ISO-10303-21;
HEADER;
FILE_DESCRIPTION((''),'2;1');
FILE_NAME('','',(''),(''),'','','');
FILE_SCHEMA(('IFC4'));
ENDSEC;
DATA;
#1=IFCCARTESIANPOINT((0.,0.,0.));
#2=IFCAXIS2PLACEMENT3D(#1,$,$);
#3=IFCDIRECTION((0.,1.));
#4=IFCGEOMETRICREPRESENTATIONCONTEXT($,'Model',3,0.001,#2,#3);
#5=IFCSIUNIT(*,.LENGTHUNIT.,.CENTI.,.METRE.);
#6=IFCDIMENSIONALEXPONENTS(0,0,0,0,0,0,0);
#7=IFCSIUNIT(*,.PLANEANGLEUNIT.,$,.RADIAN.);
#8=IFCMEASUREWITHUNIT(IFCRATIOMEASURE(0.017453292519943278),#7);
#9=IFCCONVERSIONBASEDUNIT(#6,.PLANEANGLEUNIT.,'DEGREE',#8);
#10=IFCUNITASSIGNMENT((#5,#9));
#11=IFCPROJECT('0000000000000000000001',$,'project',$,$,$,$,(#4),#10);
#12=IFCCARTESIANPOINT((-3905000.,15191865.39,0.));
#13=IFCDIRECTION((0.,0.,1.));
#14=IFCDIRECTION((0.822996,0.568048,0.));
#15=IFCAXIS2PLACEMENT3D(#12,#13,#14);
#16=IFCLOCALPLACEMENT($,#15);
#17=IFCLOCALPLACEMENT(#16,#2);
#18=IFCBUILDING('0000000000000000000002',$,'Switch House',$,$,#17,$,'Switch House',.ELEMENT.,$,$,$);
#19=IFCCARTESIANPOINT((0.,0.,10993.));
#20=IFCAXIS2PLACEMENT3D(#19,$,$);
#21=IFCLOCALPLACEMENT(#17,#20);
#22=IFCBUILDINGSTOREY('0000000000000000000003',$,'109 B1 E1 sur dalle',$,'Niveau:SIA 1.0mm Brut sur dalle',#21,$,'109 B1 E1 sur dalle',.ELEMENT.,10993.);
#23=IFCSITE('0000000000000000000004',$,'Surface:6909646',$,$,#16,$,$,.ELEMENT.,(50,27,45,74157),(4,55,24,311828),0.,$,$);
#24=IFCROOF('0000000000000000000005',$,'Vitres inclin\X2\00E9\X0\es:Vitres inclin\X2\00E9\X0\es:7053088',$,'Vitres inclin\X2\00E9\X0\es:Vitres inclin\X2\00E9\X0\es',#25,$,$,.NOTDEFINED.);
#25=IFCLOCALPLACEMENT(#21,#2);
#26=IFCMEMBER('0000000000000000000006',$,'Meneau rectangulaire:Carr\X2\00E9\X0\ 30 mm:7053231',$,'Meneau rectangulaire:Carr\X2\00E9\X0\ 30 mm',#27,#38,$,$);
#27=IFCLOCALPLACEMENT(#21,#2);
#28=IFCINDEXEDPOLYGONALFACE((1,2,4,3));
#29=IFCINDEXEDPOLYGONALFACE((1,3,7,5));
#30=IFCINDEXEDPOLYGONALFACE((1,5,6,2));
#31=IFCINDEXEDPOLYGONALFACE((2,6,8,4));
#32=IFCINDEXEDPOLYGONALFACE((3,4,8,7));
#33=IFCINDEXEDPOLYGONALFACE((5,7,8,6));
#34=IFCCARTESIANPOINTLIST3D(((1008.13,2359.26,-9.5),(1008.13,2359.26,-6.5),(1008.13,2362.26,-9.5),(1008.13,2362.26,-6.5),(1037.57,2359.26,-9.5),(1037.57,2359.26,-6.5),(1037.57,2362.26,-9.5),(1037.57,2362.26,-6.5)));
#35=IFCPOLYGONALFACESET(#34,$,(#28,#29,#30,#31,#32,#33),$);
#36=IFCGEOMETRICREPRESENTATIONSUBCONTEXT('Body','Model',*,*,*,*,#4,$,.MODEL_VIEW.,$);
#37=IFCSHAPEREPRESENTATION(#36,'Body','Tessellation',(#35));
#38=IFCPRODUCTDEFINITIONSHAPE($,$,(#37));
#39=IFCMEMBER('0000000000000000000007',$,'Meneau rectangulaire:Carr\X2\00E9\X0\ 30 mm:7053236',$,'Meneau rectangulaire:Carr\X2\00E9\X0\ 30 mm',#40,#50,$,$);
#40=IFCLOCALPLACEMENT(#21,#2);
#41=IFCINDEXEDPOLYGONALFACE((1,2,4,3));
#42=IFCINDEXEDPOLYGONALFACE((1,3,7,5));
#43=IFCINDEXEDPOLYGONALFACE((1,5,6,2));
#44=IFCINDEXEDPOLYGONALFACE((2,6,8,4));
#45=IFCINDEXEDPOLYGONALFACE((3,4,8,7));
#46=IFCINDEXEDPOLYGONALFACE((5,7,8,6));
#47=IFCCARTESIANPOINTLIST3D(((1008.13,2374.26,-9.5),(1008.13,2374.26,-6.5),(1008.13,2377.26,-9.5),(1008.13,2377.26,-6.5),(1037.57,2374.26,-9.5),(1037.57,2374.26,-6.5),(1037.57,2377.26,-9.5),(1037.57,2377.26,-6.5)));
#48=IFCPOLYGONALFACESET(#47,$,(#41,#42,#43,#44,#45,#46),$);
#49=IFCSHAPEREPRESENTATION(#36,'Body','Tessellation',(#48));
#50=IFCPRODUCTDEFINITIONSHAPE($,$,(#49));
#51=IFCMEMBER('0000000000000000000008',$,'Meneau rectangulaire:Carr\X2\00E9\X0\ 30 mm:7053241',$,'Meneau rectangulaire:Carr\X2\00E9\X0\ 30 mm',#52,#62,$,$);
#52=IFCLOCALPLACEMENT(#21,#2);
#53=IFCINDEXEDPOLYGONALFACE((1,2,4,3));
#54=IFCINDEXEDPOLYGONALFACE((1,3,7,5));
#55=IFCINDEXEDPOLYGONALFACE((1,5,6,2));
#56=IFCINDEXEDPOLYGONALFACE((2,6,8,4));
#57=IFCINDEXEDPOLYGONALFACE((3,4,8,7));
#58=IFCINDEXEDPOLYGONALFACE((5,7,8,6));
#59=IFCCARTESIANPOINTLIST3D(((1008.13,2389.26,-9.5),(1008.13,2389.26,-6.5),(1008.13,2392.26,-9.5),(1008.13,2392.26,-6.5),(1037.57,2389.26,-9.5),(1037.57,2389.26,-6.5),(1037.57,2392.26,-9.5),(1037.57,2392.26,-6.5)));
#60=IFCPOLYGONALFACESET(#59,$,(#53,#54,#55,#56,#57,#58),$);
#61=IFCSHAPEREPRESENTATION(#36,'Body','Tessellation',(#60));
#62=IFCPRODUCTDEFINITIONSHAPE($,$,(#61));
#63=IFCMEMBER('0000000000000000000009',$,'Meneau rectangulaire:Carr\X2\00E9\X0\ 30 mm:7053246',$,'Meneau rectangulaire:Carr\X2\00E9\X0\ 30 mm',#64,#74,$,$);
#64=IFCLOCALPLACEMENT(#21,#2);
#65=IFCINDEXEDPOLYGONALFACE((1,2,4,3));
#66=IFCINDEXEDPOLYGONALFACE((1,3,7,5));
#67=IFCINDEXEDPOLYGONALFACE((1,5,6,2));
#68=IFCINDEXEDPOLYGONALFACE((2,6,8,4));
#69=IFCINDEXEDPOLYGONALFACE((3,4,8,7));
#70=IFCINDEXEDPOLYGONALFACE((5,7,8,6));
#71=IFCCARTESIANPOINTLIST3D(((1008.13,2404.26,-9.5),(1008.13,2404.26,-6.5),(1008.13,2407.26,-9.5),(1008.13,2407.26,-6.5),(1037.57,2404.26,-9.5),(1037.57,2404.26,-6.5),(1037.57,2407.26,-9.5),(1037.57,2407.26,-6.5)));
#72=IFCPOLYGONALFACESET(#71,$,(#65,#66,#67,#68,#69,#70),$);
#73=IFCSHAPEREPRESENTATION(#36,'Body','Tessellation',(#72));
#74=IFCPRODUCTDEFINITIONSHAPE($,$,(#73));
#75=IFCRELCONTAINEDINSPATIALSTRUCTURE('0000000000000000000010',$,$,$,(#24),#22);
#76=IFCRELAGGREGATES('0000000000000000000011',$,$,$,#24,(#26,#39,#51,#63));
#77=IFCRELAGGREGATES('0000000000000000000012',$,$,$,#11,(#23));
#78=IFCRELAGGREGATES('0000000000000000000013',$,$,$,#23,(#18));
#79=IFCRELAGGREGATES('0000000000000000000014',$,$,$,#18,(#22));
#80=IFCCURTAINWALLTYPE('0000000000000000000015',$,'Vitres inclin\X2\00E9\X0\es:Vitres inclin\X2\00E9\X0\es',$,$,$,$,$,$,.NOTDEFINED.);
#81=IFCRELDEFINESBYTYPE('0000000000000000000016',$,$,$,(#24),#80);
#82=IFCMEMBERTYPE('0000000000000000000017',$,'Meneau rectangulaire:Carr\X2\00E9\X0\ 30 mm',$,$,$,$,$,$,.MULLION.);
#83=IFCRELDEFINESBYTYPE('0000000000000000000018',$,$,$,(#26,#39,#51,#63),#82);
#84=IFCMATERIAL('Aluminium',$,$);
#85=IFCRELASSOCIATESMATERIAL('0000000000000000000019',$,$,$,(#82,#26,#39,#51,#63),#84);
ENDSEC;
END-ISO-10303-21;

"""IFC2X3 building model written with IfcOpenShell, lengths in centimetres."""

from ifc_helpers import new_model, entity, si_unit, converted_unit, direction, frame, origin, origin_2d_with_axis, place, context, subcontext, project, spatial, rectangle, extrude, source, transform, mapped, material, type_object, type_shapes, element, aggregate, save


model = new_model("IFC2X3")

# Units and contexts
model_context = context("Model", 3, precision=0.001, world=origin(), true_north=direction((0.0, 1.0)))
body_context = subcontext(model_context, "Body", "Model", "MODEL_VIEW")
ifc_project = project(units=[si_unit("LENGTHUNIT", "METRE", prefix="CENTI"), converted_unit("PLANEANGLEUNIT", "DEGREE", entity("IfcRatioMeasure", 0.017453292519943278), si_unit("PLANEANGLEUNIT", "RADIAN"), dimensions=[0, 0, 0, 0, 0, 0, 0])], contexts=[model_context])

# Site, building, storey
site_placement = place(None, frame((-3905000.0, 15191865.39, 0.0), z_axis=(0.0, 0.0, 1.0), x_axis=(0.822996, 0.568048, 0.0)))
site = spatial("IfcSite", under=ifc_project, at=site_placement, Name="Surface:6909646", CompositionType="ELEMENT", RefLatitude=(50, 27, 45, 74157), RefLongitude=(4, 55, 24, 311828), RefElevation=0.0)
building_placement = place(site_placement, origin())
building = spatial("IfcBuilding", under=site, at=building_placement, Name="Switch House", LongName="Switch House", CompositionType="ELEMENT")
storey_placement = place(building_placement, frame((0.0, 0.0, 10993.0)))
storey = spatial("IfcBuildingStorey", under=building, at=storey_placement, Name="109 B1 E1 sur dalle", ObjectType="Niveau:SIA 1.0mm Brut sur dalle", LongName="109 B1 E1 sur dalle", CompositionType="ELEMENT", Elevation=10993.0)

# Roof, members
curtain_wall_type = type_object("IfcCurtainWallType", Name="Vitres inclinées:Vitres inclinées", PredefinedType="NOTDEFINED")
roof_placement = place(storey_placement, frame((0.0, 0.0, -10993.0)))
roof = element("IfcRoof", 1, at=roof_placement, inside=storey, type_object=curtain_wall_type, Name="Vitres inclinées:Vitres inclinées:7053088", ObjectType="Vitres inclinées:Vitres inclinées", ShapeType="NOTDEFINED")
ifc_material = material(Name="Aluminium")
member_type_1 = type_object("IfcMemberType", Name="Meneau rectangulaire:Carré 30 mm", PredefinedType="MULLION", material=ifc_material)
shared_shape_1 = source(origin(), body_context, "Body", "SweptSolid", [
    extrude(rectangle(XDim=3.0, YDim=3.0, at=origin_2d_with_axis()), frame((0.0, 0.0, -29.44), z_axis=(0.0, 0.0, 1.0), x_axis=(0.0, -1.0, 0.0)), (0.0, 0.0, 1.0), 29.44),
])
type_shapes(member_type_1, [shared_shape_1])
member_1_placement = place(roof_placement, frame((1008.13, 2360.76, 10985.0), z_axis=(-1.0, 0.0, 0.0), x_axis=(0.0, 1.0, 0.0)))
member_1 = element("IfcMember", 2, at=member_1_placement, type_object=member_type_1, material=ifc_material, Name="Meneau rectangulaire:Carré 30 mm:7053231", ObjectType="Meneau rectangulaire:Carré 30 mm", context=body_context, shape_type="MappedRepresentation", body=[
    mapped(shared_shape_1, transform((0.0, 0.0, 0.0), scale=1.0)),
])
member_2_placement = place(roof_placement, frame((1008.13, 2375.76, 10985.0), z_axis=(-1.0, 0.0, 0.0), x_axis=(0.0, 1.0, 0.0)))
member_2 = element("IfcMember", 3, at=member_2_placement, type_object=member_type_1, material=ifc_material, Name="Meneau rectangulaire:Carré 30 mm:7053236", ObjectType="Meneau rectangulaire:Carré 30 mm", context=body_context, shape_type="MappedRepresentation", body=[
    mapped(shared_shape_1, transform((0.0, 0.0, 0.0), scale=1.0)),
])
member_3_placement = place(roof_placement, frame((1008.13, 2390.76, 10985.0), z_axis=(-1.0, 0.0, 0.0), x_axis=(0.0, 1.0, 0.0)))
member_3 = element("IfcMember", 4, at=member_3_placement, type_object=member_type_1, material=ifc_material, Name="Meneau rectangulaire:Carré 30 mm:7053241", ObjectType="Meneau rectangulaire:Carré 30 mm", context=body_context, shape_type="MappedRepresentation", body=[
    mapped(shared_shape_1, transform((0.0, 0.0, 0.0), scale=1.0)),
])
member_4_placement = place(roof_placement, frame((1008.13, 2405.76, 10985.0), z_axis=(-1.0, 0.0, 0.0), x_axis=(0.0, 1.0, 0.0)))
member_4 = element("IfcMember", 5, at=member_4_placement, type_object=member_type_1, material=ifc_material, Name="Meneau rectangulaire:Carré 30 mm:7053246", ObjectType="Meneau rectangulaire:Carré 30 mm", context=body_context, shape_type="MappedRepresentation", body=[
    mapped(shared_shape_1, transform((0.0, 0.0, 0.0), scale=1.0)),
])
aggregate(roof, [member_1, member_2, member_3, member_4])

save(model, "model.ifc")
